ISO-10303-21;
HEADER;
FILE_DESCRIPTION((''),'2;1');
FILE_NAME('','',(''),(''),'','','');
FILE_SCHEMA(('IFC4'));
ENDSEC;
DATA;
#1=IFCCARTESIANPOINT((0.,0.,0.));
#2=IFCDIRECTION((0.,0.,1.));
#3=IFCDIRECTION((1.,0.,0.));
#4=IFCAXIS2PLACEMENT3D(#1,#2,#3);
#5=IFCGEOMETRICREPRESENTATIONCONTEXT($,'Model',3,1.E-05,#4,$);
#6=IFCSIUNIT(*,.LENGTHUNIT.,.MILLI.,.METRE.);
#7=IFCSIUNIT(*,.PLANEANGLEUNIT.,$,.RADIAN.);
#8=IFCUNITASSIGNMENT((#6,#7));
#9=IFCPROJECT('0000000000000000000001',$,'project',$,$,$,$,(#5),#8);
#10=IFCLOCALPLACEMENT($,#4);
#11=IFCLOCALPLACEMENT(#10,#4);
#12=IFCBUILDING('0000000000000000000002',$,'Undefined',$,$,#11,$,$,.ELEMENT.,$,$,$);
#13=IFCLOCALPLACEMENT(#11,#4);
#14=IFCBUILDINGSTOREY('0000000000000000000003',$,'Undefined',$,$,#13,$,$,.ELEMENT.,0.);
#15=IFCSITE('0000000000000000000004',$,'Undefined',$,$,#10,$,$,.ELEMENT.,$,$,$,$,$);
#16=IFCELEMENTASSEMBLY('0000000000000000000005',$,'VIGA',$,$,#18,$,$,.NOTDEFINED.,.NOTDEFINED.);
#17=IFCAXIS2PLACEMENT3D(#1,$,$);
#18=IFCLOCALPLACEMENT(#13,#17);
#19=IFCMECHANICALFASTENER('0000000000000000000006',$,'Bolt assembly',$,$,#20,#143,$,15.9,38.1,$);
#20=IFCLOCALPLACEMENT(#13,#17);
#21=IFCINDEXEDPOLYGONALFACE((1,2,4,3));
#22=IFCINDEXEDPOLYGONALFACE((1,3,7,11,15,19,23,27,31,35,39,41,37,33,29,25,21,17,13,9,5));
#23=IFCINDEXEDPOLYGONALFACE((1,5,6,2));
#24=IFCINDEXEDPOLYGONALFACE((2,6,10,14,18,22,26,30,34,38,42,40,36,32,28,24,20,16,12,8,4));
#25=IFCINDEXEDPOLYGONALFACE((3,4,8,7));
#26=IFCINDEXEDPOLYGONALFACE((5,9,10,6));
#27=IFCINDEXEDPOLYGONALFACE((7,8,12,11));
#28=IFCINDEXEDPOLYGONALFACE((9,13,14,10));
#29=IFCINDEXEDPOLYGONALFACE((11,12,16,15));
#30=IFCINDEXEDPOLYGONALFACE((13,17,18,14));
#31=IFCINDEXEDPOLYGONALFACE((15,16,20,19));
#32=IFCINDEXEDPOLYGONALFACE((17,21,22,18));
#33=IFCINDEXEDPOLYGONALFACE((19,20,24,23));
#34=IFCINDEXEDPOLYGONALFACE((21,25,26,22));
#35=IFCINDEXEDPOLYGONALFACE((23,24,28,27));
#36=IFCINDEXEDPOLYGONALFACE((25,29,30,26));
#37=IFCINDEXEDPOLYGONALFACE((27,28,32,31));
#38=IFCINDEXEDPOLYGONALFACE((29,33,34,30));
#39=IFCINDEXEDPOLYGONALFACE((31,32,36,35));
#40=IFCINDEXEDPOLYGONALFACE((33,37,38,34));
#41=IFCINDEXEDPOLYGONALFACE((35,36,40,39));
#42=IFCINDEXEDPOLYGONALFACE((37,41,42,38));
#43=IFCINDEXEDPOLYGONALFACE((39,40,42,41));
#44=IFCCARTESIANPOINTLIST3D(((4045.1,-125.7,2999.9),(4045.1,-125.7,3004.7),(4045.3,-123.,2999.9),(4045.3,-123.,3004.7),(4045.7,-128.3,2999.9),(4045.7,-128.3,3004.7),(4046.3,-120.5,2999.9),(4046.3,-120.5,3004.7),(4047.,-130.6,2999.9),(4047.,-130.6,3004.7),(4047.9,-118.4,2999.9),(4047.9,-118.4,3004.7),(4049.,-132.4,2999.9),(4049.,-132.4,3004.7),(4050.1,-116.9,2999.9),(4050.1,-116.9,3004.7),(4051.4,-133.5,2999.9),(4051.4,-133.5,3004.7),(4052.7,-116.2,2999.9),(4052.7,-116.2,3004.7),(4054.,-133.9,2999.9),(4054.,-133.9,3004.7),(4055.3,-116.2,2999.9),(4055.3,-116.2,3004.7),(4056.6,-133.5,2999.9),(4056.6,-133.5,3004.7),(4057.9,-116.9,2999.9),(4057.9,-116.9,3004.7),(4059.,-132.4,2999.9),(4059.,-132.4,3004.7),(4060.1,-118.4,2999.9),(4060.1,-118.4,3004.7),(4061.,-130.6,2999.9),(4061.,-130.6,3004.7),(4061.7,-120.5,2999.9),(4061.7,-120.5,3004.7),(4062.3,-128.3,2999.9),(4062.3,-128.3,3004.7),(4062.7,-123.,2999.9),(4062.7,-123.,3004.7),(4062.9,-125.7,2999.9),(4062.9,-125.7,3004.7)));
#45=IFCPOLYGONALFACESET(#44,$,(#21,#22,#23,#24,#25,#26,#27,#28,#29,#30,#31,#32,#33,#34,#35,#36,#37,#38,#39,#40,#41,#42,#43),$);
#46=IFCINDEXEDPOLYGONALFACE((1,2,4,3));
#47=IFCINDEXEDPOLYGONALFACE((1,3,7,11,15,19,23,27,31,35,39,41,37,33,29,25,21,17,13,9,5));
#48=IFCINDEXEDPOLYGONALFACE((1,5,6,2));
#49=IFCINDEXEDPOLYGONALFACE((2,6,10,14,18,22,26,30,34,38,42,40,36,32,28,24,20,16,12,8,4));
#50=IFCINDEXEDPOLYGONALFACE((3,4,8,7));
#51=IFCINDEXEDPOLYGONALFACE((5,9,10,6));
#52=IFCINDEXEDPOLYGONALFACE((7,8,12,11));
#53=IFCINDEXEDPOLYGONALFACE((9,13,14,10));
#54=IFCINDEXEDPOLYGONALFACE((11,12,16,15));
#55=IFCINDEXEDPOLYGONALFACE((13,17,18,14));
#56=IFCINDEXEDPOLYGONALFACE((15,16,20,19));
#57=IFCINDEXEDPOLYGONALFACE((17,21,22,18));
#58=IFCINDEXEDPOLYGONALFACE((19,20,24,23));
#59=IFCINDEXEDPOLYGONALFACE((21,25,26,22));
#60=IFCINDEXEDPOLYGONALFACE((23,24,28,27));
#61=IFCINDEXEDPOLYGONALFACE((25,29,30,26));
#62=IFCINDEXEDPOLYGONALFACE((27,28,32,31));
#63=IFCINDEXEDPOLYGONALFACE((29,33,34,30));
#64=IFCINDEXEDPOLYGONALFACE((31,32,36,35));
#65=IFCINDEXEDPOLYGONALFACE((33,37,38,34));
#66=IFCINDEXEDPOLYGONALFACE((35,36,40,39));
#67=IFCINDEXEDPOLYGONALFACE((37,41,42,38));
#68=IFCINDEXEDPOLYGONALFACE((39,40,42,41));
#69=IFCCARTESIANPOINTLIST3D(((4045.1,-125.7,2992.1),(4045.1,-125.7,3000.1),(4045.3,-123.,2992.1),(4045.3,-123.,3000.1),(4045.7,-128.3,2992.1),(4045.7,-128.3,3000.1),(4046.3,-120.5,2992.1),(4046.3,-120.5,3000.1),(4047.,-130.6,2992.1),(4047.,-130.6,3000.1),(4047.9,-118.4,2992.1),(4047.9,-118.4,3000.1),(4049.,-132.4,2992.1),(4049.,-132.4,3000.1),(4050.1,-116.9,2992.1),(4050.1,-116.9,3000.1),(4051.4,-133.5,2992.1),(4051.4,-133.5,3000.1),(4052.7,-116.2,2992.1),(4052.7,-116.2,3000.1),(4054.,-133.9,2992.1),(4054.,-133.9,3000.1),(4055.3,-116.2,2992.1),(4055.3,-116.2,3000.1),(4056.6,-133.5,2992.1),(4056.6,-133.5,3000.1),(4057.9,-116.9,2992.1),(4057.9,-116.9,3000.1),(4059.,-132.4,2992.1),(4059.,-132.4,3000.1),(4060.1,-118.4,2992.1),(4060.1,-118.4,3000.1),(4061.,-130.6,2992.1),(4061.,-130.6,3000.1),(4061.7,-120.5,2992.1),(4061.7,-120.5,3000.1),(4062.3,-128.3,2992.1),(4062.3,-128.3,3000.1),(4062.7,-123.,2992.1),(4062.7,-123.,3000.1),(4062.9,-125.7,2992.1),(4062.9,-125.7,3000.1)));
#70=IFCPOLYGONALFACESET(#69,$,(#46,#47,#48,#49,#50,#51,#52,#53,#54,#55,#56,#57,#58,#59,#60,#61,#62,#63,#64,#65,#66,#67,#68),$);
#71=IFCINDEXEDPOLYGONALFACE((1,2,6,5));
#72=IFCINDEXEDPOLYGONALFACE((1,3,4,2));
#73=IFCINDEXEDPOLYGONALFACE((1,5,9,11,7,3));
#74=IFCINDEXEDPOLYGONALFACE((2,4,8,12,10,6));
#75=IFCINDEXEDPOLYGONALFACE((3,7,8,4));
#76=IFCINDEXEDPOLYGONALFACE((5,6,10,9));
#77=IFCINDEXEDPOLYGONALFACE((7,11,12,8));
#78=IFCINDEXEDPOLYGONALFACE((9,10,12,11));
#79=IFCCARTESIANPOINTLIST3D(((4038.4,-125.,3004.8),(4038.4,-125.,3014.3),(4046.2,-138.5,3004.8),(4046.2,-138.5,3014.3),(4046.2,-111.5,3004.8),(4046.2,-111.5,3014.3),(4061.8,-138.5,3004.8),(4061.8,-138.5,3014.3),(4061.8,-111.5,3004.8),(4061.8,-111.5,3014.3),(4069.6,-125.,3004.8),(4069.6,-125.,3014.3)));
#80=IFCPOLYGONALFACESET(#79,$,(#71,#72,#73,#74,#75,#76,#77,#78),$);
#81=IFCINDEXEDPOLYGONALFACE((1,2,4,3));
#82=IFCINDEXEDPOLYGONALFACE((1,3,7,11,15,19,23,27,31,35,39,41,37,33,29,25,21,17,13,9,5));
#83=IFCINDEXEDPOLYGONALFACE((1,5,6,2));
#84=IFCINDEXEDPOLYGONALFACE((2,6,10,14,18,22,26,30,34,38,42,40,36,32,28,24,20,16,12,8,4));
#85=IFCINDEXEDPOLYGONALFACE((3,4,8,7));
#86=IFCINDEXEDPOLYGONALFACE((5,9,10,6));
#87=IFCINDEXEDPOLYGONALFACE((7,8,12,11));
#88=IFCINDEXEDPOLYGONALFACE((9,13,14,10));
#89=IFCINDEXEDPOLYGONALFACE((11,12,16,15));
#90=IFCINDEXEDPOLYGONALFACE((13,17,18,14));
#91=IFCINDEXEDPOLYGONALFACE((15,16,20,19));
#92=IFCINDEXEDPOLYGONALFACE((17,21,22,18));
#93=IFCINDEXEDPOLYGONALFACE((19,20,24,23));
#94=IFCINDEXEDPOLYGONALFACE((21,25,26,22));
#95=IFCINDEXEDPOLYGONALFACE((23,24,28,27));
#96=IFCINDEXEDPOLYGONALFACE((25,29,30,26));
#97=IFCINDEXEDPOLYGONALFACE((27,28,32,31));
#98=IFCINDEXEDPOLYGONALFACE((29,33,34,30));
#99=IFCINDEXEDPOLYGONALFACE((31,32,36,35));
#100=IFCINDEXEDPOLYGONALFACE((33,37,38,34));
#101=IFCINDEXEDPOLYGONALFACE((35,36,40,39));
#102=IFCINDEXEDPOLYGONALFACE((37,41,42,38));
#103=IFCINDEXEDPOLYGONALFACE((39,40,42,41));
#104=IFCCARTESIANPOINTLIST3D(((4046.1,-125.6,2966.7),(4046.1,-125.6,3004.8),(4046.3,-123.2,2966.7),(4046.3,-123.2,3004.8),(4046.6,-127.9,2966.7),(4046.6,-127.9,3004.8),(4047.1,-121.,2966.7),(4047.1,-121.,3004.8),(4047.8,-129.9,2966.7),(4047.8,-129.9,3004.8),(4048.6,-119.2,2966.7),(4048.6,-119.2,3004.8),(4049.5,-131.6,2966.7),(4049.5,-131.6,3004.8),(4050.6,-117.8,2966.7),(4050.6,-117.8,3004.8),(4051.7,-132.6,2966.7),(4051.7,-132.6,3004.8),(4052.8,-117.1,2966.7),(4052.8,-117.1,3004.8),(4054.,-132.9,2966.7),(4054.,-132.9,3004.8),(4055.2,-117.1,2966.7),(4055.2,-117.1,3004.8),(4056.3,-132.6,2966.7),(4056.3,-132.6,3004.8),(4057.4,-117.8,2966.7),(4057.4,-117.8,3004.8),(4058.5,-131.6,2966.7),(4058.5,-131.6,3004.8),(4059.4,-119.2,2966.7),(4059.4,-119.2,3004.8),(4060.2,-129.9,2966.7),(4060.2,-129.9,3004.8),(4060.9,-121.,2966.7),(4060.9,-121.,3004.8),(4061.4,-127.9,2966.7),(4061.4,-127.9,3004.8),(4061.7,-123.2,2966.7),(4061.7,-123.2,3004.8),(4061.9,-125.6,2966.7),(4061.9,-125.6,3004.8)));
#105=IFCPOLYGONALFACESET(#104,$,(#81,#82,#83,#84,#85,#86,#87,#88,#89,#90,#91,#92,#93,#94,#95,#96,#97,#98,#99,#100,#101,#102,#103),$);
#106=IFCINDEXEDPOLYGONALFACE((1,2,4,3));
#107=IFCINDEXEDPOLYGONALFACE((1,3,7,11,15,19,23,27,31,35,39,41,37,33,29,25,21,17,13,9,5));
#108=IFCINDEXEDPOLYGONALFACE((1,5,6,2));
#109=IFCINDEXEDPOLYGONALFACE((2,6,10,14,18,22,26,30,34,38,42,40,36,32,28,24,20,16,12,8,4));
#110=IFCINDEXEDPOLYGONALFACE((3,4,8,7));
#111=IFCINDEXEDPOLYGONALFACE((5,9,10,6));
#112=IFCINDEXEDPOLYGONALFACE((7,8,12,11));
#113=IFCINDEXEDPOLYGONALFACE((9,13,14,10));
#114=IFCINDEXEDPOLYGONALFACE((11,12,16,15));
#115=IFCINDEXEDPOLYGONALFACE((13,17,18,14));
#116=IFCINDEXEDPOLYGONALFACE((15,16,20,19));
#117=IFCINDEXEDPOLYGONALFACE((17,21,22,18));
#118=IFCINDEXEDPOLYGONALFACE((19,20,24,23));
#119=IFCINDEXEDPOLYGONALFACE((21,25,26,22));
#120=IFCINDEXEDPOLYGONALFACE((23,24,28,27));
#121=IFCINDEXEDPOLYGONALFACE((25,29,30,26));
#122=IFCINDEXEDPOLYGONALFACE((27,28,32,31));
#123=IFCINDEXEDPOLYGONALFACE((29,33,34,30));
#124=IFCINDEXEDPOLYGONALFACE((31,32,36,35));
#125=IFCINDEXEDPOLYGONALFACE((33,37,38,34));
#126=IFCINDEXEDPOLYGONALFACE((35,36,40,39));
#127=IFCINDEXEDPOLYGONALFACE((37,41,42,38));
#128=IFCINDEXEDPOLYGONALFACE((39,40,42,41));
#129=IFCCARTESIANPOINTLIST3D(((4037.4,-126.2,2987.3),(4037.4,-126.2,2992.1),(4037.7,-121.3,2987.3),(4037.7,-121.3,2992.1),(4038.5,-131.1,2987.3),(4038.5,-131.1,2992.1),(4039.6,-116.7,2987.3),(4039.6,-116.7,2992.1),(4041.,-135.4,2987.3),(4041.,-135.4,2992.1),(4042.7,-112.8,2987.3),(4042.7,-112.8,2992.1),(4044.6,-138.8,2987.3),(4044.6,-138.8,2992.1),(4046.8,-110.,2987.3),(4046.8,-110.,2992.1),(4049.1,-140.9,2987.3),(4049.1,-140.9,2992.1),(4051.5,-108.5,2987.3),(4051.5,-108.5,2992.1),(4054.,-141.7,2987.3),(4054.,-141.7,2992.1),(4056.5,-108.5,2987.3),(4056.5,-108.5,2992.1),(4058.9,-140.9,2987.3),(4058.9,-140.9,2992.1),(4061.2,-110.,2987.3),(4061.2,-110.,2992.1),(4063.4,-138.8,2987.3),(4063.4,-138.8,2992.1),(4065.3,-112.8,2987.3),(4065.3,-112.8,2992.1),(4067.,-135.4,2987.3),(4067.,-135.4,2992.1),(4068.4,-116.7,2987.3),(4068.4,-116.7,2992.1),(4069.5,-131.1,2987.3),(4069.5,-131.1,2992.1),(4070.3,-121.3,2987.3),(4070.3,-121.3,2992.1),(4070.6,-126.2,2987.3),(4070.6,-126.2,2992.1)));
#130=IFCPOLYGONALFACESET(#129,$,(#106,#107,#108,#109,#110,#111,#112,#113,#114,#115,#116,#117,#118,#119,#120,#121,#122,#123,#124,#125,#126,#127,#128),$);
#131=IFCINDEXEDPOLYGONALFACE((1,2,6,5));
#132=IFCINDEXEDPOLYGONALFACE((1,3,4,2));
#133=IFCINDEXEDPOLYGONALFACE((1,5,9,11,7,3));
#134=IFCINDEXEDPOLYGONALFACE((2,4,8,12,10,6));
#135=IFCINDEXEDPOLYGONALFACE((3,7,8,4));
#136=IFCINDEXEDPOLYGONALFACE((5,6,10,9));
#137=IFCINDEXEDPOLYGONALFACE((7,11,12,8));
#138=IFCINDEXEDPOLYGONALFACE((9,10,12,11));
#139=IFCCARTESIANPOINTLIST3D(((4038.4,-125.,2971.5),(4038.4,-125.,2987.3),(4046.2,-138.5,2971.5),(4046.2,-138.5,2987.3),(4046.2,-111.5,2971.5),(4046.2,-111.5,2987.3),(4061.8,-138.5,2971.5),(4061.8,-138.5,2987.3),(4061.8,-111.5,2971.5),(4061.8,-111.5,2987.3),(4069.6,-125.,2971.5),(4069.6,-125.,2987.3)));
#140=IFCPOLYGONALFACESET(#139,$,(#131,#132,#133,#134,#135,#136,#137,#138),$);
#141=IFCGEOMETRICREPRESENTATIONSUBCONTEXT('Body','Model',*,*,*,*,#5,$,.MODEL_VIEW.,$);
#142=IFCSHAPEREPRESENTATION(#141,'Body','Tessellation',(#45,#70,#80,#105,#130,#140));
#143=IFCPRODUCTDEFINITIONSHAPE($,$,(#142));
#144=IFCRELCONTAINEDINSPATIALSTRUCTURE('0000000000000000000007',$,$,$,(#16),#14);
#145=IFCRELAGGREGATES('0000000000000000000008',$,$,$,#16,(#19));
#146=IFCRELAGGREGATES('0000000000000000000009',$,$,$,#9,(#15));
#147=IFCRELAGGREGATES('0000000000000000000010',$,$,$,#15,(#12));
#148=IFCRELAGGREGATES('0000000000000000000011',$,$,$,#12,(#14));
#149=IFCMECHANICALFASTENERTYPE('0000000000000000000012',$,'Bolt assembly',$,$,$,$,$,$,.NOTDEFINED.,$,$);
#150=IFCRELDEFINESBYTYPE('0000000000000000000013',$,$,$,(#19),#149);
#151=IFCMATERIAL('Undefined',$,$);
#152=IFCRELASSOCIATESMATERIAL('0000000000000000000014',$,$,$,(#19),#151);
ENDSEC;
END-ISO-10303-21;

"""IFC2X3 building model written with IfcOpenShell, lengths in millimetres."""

from ifc_helpers import new_model, si_unit, frame, origin_with_axes, origin_2d_with_axis, place, context, subcontext, project, spatial, polyline, circle, outline, extrude, source, transform, mapped, material, type_object, element, aggregate, save


model = new_model("IFC2X3")

# Units and contexts
model_context = context("Model", 3, precision=1e-05, world=origin_with_axes())
body_context = subcontext(model_context, "Body", "Model", "MODEL_VIEW")
ifc_project = project(units=[si_unit("LENGTHUNIT", "METRE", prefix="MILLI"), si_unit("PLANEANGLEUNIT", "RADIAN")], contexts=[model_context])

# Site, building, storey
site_placement = place(None, origin_with_axes())
site = spatial("IfcSite", under=ifc_project, at=site_placement, Name="Undefined", CompositionType="ELEMENT")
building_placement = place(site_placement, origin_with_axes())
building = spatial("IfcBuilding", under=site, at=building_placement, Name="Undefined", CompositionType="ELEMENT")
storey_placement = place(building_placement, origin_with_axes())
storey = spatial("IfcBuildingStorey", under=building, at=storey_placement, Name="Undefined", CompositionType="ELEMENT", Elevation=0.0)

# Element assembly
assembly_1_placement = place(storey_placement, origin_with_axes())
assembly_1 = element("IfcElementAssembly", 1, at=assembly_1_placement, inside=storey, Name="VIGA", AssemblyPlace="NOTDEFINED", PredefinedType="NOTDEFINED")

# Mechanical fastener
ifc_material_1 = material(Name="Undefined")
mechanical_fastener_type = type_object("IfcMechanicalFastenerType", Name="Bolt assembly")
shared_shape_1 = source(origin_with_axes(), body_context, "Body", "SweptSolid", [
    extrude(circle(Radius=8.9, at=origin_2d_with_axis()), frame((0.0, -4.7, 0.0), z_axis=(0.0, 1.0, 0.0), x_axis=(1.0, 0.0, 0.0)), (0.0, 0.0, 1.0), 4.8),
    extrude(circle(Radius=8.9, at=origin_2d_with_axis()), frame((0.0, -0.1, 0.0), z_axis=(0.0, 1.0, 0.0), x_axis=(1.0, 0.0, 0.0)), (0.0, 0.0, 1.0), 8.0),
    extrude(outline(polyline([(13.5, -7.8), (13.5, 7.8), (0.0, 15.6), (-13.5, 7.8), (-13.5, -7.8), (0.0, -15.6), (13.5, -7.8)])), frame((0.0, -14.3, 0.0), z_axis=(0.0, 1.0, 0.0), x_axis=(1.0, 0.0, 0.0)), (0.0, 0.0, 1.0), 9.5),
    extrude(circle(Radius=7.9, at=origin_2d_with_axis()), frame((0.0, -4.8, 0.0), z_axis=(0.0, 1.0, 0.0), x_axis=(1.0, 0.0, 0.0)), (0.0, 0.0, 1.0), 38.1),
    extrude(circle(Radius=16.7, at=origin_2d_with_axis()), frame((0.0, 7.9, 0.0), z_axis=(0.0, 1.0, 0.0), x_axis=(1.0, 0.0, 0.0)), (0.0, 0.0, 1.0), 4.8),
    extrude(outline(polyline([(13.5, -7.8), (13.5, 7.8), (0.0, 15.6), (-13.5, 7.8), (-13.5, -7.8), (0.0, -15.6), (13.5, -7.8)])), frame((0.0, 12.7, 0.0), z_axis=(0.0, 1.0, 0.0), x_axis=(1.0, 0.0, 0.0)), (0.0, 0.0, 1.0), 15.9),
])
mechanical_fastener_1_placement = place(assembly_1_placement, frame((4054.0, -125.0, 3000.0), z_axis=(1.0, -0.000001, 0.0), x_axis=(-0.000001, -1.0, 0.0)))
mechanical_fastener_1 = element("IfcMechanicalFastener", 2, at=mechanical_fastener_1_placement, type_object=mechanical_fastener_type, material=ifc_material_1, Name="Bolt assembly", NominalDiameter=15.9, NominalLength=38.1, context=body_context, shape_type="MappedRepresentation", body=[
    mapped(shared_shape_1, transform((0.0, 0.0, 0.0))),
])
aggregate(assembly_1, [mechanical_fastener_1])

save(model, "model.ifc")
